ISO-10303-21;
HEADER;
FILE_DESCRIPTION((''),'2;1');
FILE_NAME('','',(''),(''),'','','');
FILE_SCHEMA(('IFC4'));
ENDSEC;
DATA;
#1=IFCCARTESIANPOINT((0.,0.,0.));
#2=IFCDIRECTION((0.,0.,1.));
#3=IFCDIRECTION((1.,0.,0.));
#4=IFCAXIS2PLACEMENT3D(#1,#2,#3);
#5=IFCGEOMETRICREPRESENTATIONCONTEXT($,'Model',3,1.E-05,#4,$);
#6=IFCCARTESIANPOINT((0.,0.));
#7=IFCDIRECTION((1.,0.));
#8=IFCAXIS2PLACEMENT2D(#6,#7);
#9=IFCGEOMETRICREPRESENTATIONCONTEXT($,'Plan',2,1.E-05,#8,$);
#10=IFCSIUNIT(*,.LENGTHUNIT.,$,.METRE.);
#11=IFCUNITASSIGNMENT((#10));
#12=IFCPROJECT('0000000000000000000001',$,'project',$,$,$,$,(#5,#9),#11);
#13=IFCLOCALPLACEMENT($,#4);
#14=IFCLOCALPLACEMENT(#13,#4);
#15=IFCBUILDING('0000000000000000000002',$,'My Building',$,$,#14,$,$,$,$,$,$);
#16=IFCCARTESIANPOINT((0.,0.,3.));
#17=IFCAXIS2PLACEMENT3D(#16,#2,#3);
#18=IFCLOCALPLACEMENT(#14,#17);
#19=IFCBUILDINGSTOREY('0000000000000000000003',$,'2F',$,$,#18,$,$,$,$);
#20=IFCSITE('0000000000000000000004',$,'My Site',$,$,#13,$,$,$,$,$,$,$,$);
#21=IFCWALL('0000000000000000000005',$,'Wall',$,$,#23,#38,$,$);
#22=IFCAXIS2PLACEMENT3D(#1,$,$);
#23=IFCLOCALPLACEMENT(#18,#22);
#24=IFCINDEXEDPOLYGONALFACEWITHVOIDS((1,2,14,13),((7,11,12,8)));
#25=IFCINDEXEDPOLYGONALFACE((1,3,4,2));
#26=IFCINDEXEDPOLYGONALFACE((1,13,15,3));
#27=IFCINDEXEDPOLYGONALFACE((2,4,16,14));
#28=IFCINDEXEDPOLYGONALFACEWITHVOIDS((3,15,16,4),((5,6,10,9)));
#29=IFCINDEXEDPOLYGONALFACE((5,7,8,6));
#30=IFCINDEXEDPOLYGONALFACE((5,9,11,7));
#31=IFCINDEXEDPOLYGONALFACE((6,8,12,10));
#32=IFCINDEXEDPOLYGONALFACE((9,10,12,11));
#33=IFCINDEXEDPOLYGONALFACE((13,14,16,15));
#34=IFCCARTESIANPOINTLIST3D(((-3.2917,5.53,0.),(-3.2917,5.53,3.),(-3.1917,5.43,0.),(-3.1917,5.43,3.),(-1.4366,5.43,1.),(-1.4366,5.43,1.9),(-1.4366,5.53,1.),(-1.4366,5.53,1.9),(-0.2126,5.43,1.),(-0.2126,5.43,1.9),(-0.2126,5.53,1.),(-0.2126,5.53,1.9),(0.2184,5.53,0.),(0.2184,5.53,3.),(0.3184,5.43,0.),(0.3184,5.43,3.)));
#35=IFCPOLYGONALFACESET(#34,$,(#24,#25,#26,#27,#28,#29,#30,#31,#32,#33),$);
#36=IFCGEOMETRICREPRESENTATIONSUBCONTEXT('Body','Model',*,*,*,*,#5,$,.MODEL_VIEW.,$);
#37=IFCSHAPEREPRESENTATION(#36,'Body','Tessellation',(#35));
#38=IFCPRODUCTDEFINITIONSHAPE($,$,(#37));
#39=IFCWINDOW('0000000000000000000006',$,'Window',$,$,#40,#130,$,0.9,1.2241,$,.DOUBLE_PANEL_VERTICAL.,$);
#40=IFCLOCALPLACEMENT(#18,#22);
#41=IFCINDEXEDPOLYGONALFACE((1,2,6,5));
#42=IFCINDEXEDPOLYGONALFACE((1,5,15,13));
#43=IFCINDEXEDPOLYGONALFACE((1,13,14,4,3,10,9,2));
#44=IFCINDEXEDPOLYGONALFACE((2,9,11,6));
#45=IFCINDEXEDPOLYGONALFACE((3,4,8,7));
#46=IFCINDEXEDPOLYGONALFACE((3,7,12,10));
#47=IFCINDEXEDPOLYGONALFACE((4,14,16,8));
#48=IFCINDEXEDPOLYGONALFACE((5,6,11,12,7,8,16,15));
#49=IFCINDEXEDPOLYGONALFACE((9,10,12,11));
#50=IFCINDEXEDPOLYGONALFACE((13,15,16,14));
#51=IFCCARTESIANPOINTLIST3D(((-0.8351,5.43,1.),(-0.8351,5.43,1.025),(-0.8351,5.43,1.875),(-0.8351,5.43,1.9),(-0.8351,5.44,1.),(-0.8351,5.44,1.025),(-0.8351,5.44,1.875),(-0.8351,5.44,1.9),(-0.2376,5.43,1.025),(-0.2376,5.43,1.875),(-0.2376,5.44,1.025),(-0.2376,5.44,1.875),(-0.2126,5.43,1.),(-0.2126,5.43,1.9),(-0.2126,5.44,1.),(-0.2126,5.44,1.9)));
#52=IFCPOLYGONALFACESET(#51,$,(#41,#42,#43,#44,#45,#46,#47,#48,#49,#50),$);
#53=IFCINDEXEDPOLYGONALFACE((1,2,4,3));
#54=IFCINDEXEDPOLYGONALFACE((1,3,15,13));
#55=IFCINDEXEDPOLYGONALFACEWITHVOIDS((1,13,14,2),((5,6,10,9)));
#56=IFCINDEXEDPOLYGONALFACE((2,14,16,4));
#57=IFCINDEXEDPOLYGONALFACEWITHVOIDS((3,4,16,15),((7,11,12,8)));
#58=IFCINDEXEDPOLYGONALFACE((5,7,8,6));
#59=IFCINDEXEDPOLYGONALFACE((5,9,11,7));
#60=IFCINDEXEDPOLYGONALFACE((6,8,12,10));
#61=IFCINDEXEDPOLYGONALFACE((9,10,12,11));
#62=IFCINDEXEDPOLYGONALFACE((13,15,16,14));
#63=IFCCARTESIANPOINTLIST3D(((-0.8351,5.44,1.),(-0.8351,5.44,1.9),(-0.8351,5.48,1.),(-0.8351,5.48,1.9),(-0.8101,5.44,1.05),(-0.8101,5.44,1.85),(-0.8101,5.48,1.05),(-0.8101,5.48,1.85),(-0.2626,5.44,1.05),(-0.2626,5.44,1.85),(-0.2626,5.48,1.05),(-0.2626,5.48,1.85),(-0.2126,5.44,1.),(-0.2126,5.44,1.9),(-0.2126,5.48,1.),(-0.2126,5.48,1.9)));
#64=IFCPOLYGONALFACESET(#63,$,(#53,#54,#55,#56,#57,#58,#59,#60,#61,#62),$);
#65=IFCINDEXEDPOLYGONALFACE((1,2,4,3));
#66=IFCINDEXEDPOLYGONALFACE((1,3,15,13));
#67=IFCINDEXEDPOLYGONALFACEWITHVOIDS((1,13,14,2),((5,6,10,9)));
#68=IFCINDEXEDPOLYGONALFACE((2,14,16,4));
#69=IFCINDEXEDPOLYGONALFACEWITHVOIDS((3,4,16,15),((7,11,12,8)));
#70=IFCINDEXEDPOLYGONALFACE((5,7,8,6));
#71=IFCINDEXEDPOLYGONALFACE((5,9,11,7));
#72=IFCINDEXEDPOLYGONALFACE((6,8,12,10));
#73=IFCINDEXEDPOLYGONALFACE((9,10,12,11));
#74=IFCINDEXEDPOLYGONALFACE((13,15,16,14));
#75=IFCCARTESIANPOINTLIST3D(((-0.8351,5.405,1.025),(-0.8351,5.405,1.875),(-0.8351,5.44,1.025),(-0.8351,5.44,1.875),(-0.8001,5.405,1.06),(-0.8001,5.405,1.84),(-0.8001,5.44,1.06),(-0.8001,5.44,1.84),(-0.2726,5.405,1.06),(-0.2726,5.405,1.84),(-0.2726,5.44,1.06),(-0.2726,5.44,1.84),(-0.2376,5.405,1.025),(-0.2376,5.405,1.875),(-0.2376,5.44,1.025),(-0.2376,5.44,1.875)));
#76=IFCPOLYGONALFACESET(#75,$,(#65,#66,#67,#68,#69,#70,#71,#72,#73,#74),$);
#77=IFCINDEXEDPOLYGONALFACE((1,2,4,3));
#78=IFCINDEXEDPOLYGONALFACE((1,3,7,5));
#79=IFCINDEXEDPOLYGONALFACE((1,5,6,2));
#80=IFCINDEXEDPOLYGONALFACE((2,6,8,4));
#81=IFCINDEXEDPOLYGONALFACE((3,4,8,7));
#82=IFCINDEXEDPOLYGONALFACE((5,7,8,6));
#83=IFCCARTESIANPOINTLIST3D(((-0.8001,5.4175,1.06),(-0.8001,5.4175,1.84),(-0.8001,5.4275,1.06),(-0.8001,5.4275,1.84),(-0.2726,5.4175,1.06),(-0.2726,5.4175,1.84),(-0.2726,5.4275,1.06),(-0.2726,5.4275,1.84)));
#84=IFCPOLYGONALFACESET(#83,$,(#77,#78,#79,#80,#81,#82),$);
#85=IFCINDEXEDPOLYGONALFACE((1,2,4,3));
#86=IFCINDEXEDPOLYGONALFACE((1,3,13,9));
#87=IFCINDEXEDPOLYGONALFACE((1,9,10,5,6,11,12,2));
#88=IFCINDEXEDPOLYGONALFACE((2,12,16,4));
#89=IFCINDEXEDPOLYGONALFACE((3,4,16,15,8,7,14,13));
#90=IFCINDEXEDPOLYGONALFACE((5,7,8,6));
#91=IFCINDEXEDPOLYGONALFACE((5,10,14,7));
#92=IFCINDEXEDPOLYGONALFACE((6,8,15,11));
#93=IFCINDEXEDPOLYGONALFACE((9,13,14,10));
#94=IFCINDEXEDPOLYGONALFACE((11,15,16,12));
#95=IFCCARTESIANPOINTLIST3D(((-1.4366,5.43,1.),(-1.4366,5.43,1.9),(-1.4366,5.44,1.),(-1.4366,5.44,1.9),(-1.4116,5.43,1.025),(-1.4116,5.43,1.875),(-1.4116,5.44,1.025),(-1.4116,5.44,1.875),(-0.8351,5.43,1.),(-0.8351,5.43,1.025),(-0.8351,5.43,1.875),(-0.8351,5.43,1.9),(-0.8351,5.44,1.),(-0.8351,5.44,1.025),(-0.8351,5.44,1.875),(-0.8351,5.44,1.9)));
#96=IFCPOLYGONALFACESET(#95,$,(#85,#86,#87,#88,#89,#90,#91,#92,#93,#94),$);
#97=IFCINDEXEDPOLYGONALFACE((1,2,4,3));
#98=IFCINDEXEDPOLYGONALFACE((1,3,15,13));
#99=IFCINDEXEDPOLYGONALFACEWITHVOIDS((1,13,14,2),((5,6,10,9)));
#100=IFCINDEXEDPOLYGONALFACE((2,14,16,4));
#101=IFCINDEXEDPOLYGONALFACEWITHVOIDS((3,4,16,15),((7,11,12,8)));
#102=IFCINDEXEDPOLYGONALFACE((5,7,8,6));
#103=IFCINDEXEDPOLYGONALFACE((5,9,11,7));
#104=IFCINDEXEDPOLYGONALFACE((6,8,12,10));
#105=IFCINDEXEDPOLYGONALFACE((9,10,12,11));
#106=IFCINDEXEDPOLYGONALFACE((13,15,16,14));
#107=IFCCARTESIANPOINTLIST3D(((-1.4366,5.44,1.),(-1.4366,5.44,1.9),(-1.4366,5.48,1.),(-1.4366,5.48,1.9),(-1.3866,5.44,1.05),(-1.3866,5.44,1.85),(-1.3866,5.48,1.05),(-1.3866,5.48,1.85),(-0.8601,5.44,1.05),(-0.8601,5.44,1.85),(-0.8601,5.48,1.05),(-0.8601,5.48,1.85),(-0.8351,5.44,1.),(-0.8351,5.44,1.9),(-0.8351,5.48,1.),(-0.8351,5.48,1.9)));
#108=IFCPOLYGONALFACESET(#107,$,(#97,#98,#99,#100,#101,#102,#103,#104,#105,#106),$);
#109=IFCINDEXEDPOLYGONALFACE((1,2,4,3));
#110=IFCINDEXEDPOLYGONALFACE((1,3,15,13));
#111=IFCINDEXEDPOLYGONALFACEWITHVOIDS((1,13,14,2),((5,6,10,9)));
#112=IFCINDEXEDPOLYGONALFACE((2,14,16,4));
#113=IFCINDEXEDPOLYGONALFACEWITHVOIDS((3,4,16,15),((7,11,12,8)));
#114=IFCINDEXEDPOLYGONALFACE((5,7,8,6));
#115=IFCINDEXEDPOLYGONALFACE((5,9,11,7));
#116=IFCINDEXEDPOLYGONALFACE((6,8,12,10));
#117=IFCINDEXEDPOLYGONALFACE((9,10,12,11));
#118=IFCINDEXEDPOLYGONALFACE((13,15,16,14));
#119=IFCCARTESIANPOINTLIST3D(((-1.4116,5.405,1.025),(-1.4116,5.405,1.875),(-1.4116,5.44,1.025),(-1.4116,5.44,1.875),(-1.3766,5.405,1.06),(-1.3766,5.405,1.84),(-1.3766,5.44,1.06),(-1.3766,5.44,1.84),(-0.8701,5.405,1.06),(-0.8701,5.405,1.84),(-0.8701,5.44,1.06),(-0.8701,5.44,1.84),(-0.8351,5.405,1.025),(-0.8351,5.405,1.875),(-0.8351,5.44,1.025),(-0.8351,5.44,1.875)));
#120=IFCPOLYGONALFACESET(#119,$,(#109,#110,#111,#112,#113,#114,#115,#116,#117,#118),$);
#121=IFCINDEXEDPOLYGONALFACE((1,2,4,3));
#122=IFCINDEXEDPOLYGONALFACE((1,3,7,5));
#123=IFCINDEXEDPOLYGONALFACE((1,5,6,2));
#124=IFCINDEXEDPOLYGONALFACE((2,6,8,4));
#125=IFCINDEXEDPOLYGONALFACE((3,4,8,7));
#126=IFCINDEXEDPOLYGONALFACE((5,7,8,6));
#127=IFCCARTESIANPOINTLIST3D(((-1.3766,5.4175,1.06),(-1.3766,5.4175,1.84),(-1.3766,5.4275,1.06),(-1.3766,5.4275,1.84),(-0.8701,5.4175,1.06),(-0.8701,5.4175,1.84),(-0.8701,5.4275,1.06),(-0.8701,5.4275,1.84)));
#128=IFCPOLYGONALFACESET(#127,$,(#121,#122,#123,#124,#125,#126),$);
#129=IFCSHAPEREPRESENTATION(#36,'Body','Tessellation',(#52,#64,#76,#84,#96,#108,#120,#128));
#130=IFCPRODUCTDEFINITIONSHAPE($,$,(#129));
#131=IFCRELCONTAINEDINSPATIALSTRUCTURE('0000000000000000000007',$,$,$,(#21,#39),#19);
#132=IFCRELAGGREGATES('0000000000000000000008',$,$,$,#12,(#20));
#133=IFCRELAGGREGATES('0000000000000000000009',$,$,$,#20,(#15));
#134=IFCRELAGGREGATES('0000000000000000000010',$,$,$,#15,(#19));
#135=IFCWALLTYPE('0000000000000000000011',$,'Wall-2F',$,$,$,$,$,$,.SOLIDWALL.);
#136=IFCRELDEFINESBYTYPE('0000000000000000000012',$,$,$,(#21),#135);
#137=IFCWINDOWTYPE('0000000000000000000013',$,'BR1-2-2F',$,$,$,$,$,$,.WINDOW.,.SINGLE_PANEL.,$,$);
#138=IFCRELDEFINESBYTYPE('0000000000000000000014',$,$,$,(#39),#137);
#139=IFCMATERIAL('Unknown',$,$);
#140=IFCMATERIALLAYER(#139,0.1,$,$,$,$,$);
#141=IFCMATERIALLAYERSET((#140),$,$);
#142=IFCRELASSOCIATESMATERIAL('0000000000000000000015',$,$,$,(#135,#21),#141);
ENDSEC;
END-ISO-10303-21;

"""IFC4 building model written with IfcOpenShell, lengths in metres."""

from ifc_helpers import new_model, entity, si_unit, frame, origin_with_axes, origin_2d_with_axis, place, context, subcontext, project, spatial, line, indexed_curve, outline, extrude, shape, source, transform, mapped, material, layer, layer_set, layer_usage, type_object, type_shapes, element, fill, save


model = new_model("IFC4")

# Units and contexts
model_context = context("Model", 3, precision=1e-05, world=origin_with_axes())
plan_context = context("Plan", 2, precision=1e-05, world=origin_2d_with_axis())
body_context_1 = subcontext(model_context, "Body", "Model", "MODEL_VIEW")
body_context_2 = subcontext(plan_context, "Body", "Plan", "PLAN_VIEW")
ifc_project = project(units=[si_unit("LENGTHUNIT", "METRE")], contexts=[model_context, plan_context])

# Site, building, storey
site_placement = place(None, origin_with_axes())
site = spatial("IfcSite", under=ifc_project, at=site_placement, Name="My Site")
building_placement = place(site_placement, origin_with_axes())
building = spatial("IfcBuilding", under=site, at=building_placement, Name="My Building")
storey_placement = place(building_placement, frame((0.0, 0.0, 3.0), z_axis=(0.0, 0.0, 1.0), x_axis=(1.0, 0.0, 0.0)))
storey = spatial("IfcBuildingStorey", under=building, at=storey_placement, Name="2F")

# Shared definitions
ifc_material = material(Name="Unknown")

# Shared definitions
ifc_layer_1 = layer(ifc_material, 0.1)
ifc_layer_set_1 = layer_set([ifc_layer_1])
wall_type = type_object("IfcWallType", Name="Wall-2F", PredefinedType="SOLIDWALL", material=ifc_layer_set_1)

# Wall, opening, window
ifc_layer_usage_1 = layer_usage(ifc_layer_set_1, "AXIS2", "POSITIVE", 0.0)
wall_1_placement = place(storey_placement, frame((0.2184, 5.53, 0.0), z_axis=(0.0, 0.0, 1.0), x_axis=(-1.0, 0.0, 0.0)))
wall_1 = element("IfcWall", 1, at=wall_1_placement, inside=storey, type_object=wall_type, material=ifc_layer_usage_1, Name="Wall", context=body_context_1, shape_type="SweptSolid", body=[
    extrude(outline(indexed_curve([(0.0, 0.0), (-0.1, 0.1), (3.41, 0.1), (3.51, 0.0)], segments=[line(1, 2, 3, 4, 1)])), origin_with_axes(), (0.0, 0.0, 1.0), 3.0),
])
shared_shape_1 = source(origin_with_axes(), body_context_1, "Body", "SweptSolid", [
    extrude(outline(indexed_curve([(0.0, 0.0), (1.2241, 0.0), (1.2241, 0.9), (0.0, 0.9)], segments=[line(1, 2, 3, 4, 1)])), frame((0.0, -0.6, 0.0), z_axis=(0.0, -1.0, 0.0), x_axis=(1.0, 0.0, 0.0)), (0.0, 0.0, -1.0), 1.2),
])
opening_1_placement = place(wall_1_placement, frame((0.4309, 0.0, 1.0), z_axis=(0.0, 0.0, 1.0), x_axis=(1.0, 0.0, 0.0)))
opening_1 = element("IfcOpeningElement", 2, at=opening_1_placement, cuts=wall_1, PredefinedType="OPENING", context=body_context_1, shape_type="MappedRepresentation", body=[
    mapped(shared_shape_1, transform((0.0, 0.0, 0.0), x_axis=(1.0, 0.0, 0.0), y_axis=(0.0, 1.0, 0.0), z_axis=(0.0, 0.0, 1.0), scale=1.0)),
])
window_type_1 = type_object("IfcWindowType", Name="BR1-2-2F", PartitioningType="SINGLE_PANEL", PredefinedType="WINDOW")
shared_shape_2 = source(origin_with_axes(), body_context_1, "Body", "SweptSolid", [
    extrude(outline(indexed_curve([(0.6225, 0.0), (0.0, 0.0), (0.0, 0.9), (0.6225, 0.9), (0.6225, 0.875), (0.025, 0.875), (0.025, 0.025), (0.6225, 0.025)], segments=[line(1, 2, 3, 4, 5, 6, 7, 8, 1)])), frame((0.0, 0.09, 0.0), z_axis=(0.0, -1.0, 0.0), x_axis=(1.0, 0.0, 0.0)), (0.0, 0.0, -1.0), 0.01),
    extrude(outline(indexed_curve([(0.0, 0.0), (0.6225, 0.0), (0.6225, 0.9), (0.0, 0.9)], segments=[line(1, 2, 3, 4, 1)]), holes=[indexed_curve([(0.05, 0.05), (0.5975, 0.05), (0.5975, 0.85), (0.05, 0.85)], segments=[line(1, 2, 3, 4, 1)])]), frame((0.0, 0.05, 0.0), z_axis=(0.0, -1.0, 0.0), x_axis=(1.0, 0.0, 0.0)), (0.0, 0.0, -1.0), 0.04),
    extrude(outline(indexed_curve([(0.0, 0.0), (0.5975, 0.0), (0.5975, 0.85), (0.0, 0.85)], segments=[line(1, 2, 3, 4, 1)]), holes=[indexed_curve([(0.035, 0.035), (0.5625, 0.035), (0.5625, 0.815), (0.035, 0.815)], segments=[line(1, 2, 3, 4, 1)])]), frame((0.025, 0.09, 0.025), z_axis=(0.0, -1.0, 0.0), x_axis=(1.0, 0.0, 0.0)), (0.0, 0.0, -1.0), 0.035),
    extrude(outline(indexed_curve([(0.035, 0.035), (0.5625, 0.035), (0.5625, 0.815), (0.035, 0.815)], segments=[line(1, 2, 3, 4, 1)])), frame((0.025, 0.1025, 0.025), z_axis=(0.0, -1.0, 0.0), x_axis=(1.0, 0.0, 0.0)), (0.0, 0.0, -1.0), 0.01),
    extrude(outline(indexed_curve([(0.0, 0.9), (0.6016, 0.9), (0.6016, 0.0), (0.0, 0.0), (0.0, 0.025), (0.5766, 0.025), (0.5766, 0.875), (0.0, 0.875)], segments=[line(1, 2, 3, 4, 5, 6, 7, 8, 1)])), frame((0.6225, 0.09, 0.0), z_axis=(0.0, -1.0, 0.0), x_axis=(1.0, 0.0, 0.0)), (0.0, 0.0, -1.0), 0.01),
    extrude(outline(indexed_curve([(0.0, 0.0), (0.6016, 0.0), (0.6016, 0.9), (0.0, 0.9)], segments=[line(1, 2, 3, 4, 1)]), holes=[indexed_curve([(0.025, 0.05), (0.5516, 0.05), (0.5516, 0.85), (0.025, 0.85)], segments=[line(1, 2, 3, 4, 1)])]), frame((0.6225, 0.05, 0.0), z_axis=(0.0, -1.0, 0.0), x_axis=(1.0, 0.0, 0.0)), (0.0, 0.0, -1.0), 0.04),
    extrude(outline(indexed_curve([(0.0, 0.0), (0.5766, 0.0), (0.5766, 0.85), (0.0, 0.85)], segments=[line(1, 2, 3, 4, 1)]), holes=[indexed_curve([(0.035, 0.035), (0.5416, 0.035), (0.5416, 0.815), (0.035, 0.815)], segments=[line(1, 2, 3, 4, 1)])]), frame((0.6225, 0.09, 0.025), z_axis=(0.0, -1.0, 0.0), x_axis=(1.0, 0.0, 0.0)), (0.0, 0.0, -1.0), 0.035),
    extrude(outline(indexed_curve([(0.035, 0.035), (0.5416, 0.035), (0.5416, 0.815), (0.035, 0.815)], segments=[line(1, 2, 3, 4, 1)])), frame((0.6225, 0.1025, 0.025), z_axis=(0.0, -1.0, 0.0), x_axis=(1.0, 0.0, 0.0)), (0.0, 0.0, -1.0), 0.01),
])
shared_shape_3 = source(origin_with_axes(), body_context_2, "Body", "Curve2D", [
    entity("IfcIndexedPolyCurve", entity("IfcCartesianPointList2D", [[0.05, 0.05], [0.5975, 0.05]])),
    entity("IfcIndexedPolyCurve", entity("IfcCartesianPointList2D", [[0.0, 0.1], [0.025, 0.1], [0.025, 0.09], [0.05, 0.09], [0.05, 0.05], [0.0, 0.05]]), [entity("IfcLineIndex", [1, 2, 3, 4, 5, 6, 1])]),
    entity("IfcIndexedPolyCurve", entity("IfcCartesianPointList2D", [[0.6225, 0.1], [0.6225, 0.1], [0.6225, 0.09], [0.5975, 0.09], [0.5975, 0.05], [0.6225, 0.05]])),
    entity("IfcIndexedPolyCurve", entity("IfcCartesianPointList2D", [[0.025, 0.09], [0.06, 0.09], [0.06, 0.125], [0.025, 0.125]]), [entity("IfcLineIndex", [1, 2, 3, 4, 1])]),
    entity("IfcIndexedPolyCurve", entity("IfcCartesianPointList2D", [[0.6225, 0.09], [0.5875, 0.09], [0.5875, 0.125], [0.6225, 0.125]]), [entity("IfcLineIndex", [1, 2, 3, 4, 1])]),
    entity("IfcIndexedPolyCurve", entity("IfcCartesianPointList2D", [[0.06, 0.09], [0.5875, 0.09]])),
    entity("IfcIndexedPolyCurve", entity("IfcCartesianPointList2D", [[0.06, 0.125], [0.5875, 0.125]])),
    entity("IfcIndexedPolyCurve", entity("IfcCartesianPointList2D", [[0.06, 0.1075], [0.5875, 0.1075]])),
    entity("IfcIndexedPolyCurve", entity("IfcCartesianPointList2D", [[0.6475, 0.05], [1.1741, 0.05]])),
    entity("IfcIndexedPolyCurve", entity("IfcCartesianPointList2D", [[0.6225, 0.1], [0.6225, 0.1], [0.6225, 0.09], [0.6475, 0.09], [0.6475, 0.05], [0.6225, 0.05]])),
    entity("IfcIndexedPolyCurve", entity("IfcCartesianPointList2D", [[1.2241, 0.1], [1.1991, 0.1], [1.1991, 0.09], [1.1741, 0.09], [1.1741, 0.05], [1.2241, 0.05]]), [entity("IfcLineIndex", [1, 2, 3, 4, 5, 6, 1])]),
    entity("IfcIndexedPolyCurve", entity("IfcCartesianPointList2D", [[0.6225, 0.09], [0.6575, 0.09], [0.6575, 0.125], [0.6225, 0.125]]), [entity("IfcLineIndex", [1, 2, 3, 4, 1])]),
    entity("IfcIndexedPolyCurve", entity("IfcCartesianPointList2D", [[1.1991, 0.09], [1.1641, 0.09], [1.1641, 0.125], [1.1991, 0.125]]), [entity("IfcLineIndex", [1, 2, 3, 4, 1])]),
    entity("IfcIndexedPolyCurve", entity("IfcCartesianPointList2D", [[0.6575, 0.09], [1.1641, 0.09]])),
    entity("IfcIndexedPolyCurve", entity("IfcCartesianPointList2D", [[0.6575, 0.125], [1.1641, 0.125]])),
    entity("IfcIndexedPolyCurve", entity("IfcCartesianPointList2D", [[0.6575, 0.1075], [1.1641, 0.1075]])),
])
type_shapes(window_type_1, [shared_shape_2, shared_shape_3])
window_1_placement = place(opening_1_placement, frame((0.0, 0.0, 0.0), z_axis=(0.0, 0.0, 1.0), x_axis=(1.0, 0.0, 0.0)))
window_1 = element("IfcWindow", 3, at=window_1_placement, inside=storey, type_object=window_type_1, Name="Window", OverallHeight=0.9, OverallWidth=1.2241, PartitioningType="DOUBLE_PANEL_VERTICAL", shapes=[
    shape(body_context_1, "Body", "MappedRepresentation", [mapped(shared_shape_2, transform((0.0, 0.0, 0.0), x_axis=(1.0, 0.0, 0.0), y_axis=(0.0, 1.0, 0.0), z_axis=(0.0, 0.0, 1.0), scale=1.0))]),
    shape(body_context_2, "Body", "MappedRepresentation", [mapped(shared_shape_3, transform((0.0, 0.0, 0.0), x_axis=(1.0, 0.0, 0.0), y_axis=(0.0, 1.0, 0.0), z_axis=(0.0, 0.0, 1.0), scale=1.0))]),
])
fill(opening_1, window_1)

save(model, "model.ifc")
